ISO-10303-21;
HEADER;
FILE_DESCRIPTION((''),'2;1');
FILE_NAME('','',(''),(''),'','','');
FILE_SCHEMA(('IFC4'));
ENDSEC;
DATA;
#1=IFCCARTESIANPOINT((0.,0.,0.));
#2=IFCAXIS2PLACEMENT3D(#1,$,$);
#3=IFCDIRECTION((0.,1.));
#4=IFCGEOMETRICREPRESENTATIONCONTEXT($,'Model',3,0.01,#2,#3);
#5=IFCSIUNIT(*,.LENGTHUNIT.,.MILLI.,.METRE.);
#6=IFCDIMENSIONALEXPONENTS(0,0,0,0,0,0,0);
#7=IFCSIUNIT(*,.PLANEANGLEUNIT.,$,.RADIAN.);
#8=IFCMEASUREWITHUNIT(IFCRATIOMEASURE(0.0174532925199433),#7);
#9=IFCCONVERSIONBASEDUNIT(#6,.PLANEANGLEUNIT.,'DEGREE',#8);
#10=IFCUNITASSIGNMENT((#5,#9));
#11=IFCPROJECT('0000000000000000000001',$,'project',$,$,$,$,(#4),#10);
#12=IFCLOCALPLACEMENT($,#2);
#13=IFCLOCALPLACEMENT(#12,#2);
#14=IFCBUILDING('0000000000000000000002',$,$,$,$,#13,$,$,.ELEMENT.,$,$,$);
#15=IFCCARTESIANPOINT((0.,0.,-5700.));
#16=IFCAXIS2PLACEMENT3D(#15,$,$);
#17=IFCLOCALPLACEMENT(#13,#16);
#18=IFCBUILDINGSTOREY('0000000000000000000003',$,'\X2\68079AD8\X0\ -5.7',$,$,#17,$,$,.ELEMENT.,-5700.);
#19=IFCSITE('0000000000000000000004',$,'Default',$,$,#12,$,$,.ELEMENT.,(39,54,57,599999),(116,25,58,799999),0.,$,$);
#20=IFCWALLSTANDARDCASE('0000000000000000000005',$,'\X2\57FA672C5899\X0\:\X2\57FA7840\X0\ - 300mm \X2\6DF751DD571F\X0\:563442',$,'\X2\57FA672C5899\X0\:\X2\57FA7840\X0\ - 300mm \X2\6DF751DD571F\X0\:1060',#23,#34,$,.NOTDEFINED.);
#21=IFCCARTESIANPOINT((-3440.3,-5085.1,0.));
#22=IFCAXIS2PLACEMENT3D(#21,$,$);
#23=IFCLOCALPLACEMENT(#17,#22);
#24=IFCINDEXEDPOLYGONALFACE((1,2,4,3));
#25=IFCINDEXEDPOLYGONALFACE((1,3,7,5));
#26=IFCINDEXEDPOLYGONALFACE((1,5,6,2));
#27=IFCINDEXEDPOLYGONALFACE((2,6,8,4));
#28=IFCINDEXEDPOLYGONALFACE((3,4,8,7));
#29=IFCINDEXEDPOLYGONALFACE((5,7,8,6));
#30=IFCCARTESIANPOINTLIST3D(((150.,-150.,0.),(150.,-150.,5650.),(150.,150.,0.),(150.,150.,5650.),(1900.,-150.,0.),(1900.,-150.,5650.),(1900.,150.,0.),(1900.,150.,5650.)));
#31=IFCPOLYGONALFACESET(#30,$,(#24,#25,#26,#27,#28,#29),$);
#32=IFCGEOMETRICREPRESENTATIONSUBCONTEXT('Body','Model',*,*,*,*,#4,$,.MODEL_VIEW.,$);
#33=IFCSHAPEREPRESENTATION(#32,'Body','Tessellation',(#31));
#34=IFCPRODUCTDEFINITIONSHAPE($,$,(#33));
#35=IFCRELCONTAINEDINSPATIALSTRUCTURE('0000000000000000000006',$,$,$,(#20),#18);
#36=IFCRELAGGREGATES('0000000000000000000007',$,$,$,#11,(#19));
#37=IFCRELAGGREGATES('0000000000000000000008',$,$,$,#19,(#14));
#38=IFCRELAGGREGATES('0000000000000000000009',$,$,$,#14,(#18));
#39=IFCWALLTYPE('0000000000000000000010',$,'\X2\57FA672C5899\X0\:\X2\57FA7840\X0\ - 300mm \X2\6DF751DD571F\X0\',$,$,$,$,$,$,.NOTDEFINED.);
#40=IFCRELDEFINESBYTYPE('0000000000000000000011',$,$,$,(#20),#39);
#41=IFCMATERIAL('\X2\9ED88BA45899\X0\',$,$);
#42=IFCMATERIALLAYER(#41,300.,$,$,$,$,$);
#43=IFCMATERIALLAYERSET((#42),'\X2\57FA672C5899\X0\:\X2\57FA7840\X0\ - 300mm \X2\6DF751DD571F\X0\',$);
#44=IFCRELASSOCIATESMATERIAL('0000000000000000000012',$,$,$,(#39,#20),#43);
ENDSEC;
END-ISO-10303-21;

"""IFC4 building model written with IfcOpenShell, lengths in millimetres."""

from ifc_helpers import new_model, entity, si_unit, converted_unit, direction, frame, frame_2d, origin, place, context, subcontext, project, spatial, rectangle, extrude, material, layer, layer_set, layer_usage, type_object, element, save


model = new_model("IFC4")

# Units and contexts
model_context = context("Model", 3, precision=0.01, world=origin(), true_north=direction((0.0, 1.0)))
body_context = subcontext(model_context, "Body", "Model", "MODEL_VIEW")
ifc_project = project(units=[si_unit("LENGTHUNIT", "METRE", prefix="MILLI"), converted_unit("PLANEANGLEUNIT", "DEGREE", entity("IfcRatioMeasure", 0.0174532925199433), si_unit("PLANEANGLEUNIT", "RADIAN"), dimensions=[0, 0, 0, 0, 0, 0, 0])], contexts=[model_context])

# Site, building, storey
site_placement = place(None, origin())
site = spatial("IfcSite", under=ifc_project, at=site_placement, Name="Default", CompositionType="ELEMENT", RefLatitude=(39, 54, 57, 599999), RefLongitude=(116, 25, 58, 799999), RefElevation=0.0)
building_placement = place(site_placement, origin())
building = spatial("IfcBuilding", under=site, at=building_placement, CompositionType="ELEMENT")
storey_placement = place(building_placement, frame((0.0, 0.0, -5700.0)))
storey = spatial("IfcBuildingStorey", under=building, at=storey_placement, Name="标高 -5.7", CompositionType="ELEMENT", Elevation=-5700.0)

# Wall
ifc_material_1 = material(Name="默认墙")
ifc_layer_1 = layer(ifc_material_1, 300.0)
ifc_layer_set_1 = layer_set([ifc_layer_1], Name="基本墙:基础 - 300mm 混凝土")
wall_type = type_object("IfcWallType", Name="基本墙:基础 - 300mm 混凝土", PredefinedType="NOTDEFINED", material=ifc_layer_set_1)
ifc_layer_usage_1 = layer_usage(ifc_layer_set_1, "AXIS2", "NEGATIVE", 150.0)
wall_1_placement = place(storey_placement, frame((-3440.3, -5085.1, 0.0)))
element("IfcWallStandardCase", 1, at=wall_1_placement, inside=storey, type_object=wall_type, material=ifc_layer_usage_1, Name="基本墙:基础 - 300mm 混凝土:563442", ObjectType="基本墙:基础 - 300mm 混凝土:1060", PredefinedType="NOTDEFINED", context=body_context, shape_type="SweptSolid", body=[
    extrude(rectangle(XDim=1750.0, YDim=300.0, at=frame_2d((1025.0, 0.0), x_axis=(-1.0, 0.0))), origin(), (0.0, 0.0, 1.0), 5650.0),
])

save(model, "model.ifc")
